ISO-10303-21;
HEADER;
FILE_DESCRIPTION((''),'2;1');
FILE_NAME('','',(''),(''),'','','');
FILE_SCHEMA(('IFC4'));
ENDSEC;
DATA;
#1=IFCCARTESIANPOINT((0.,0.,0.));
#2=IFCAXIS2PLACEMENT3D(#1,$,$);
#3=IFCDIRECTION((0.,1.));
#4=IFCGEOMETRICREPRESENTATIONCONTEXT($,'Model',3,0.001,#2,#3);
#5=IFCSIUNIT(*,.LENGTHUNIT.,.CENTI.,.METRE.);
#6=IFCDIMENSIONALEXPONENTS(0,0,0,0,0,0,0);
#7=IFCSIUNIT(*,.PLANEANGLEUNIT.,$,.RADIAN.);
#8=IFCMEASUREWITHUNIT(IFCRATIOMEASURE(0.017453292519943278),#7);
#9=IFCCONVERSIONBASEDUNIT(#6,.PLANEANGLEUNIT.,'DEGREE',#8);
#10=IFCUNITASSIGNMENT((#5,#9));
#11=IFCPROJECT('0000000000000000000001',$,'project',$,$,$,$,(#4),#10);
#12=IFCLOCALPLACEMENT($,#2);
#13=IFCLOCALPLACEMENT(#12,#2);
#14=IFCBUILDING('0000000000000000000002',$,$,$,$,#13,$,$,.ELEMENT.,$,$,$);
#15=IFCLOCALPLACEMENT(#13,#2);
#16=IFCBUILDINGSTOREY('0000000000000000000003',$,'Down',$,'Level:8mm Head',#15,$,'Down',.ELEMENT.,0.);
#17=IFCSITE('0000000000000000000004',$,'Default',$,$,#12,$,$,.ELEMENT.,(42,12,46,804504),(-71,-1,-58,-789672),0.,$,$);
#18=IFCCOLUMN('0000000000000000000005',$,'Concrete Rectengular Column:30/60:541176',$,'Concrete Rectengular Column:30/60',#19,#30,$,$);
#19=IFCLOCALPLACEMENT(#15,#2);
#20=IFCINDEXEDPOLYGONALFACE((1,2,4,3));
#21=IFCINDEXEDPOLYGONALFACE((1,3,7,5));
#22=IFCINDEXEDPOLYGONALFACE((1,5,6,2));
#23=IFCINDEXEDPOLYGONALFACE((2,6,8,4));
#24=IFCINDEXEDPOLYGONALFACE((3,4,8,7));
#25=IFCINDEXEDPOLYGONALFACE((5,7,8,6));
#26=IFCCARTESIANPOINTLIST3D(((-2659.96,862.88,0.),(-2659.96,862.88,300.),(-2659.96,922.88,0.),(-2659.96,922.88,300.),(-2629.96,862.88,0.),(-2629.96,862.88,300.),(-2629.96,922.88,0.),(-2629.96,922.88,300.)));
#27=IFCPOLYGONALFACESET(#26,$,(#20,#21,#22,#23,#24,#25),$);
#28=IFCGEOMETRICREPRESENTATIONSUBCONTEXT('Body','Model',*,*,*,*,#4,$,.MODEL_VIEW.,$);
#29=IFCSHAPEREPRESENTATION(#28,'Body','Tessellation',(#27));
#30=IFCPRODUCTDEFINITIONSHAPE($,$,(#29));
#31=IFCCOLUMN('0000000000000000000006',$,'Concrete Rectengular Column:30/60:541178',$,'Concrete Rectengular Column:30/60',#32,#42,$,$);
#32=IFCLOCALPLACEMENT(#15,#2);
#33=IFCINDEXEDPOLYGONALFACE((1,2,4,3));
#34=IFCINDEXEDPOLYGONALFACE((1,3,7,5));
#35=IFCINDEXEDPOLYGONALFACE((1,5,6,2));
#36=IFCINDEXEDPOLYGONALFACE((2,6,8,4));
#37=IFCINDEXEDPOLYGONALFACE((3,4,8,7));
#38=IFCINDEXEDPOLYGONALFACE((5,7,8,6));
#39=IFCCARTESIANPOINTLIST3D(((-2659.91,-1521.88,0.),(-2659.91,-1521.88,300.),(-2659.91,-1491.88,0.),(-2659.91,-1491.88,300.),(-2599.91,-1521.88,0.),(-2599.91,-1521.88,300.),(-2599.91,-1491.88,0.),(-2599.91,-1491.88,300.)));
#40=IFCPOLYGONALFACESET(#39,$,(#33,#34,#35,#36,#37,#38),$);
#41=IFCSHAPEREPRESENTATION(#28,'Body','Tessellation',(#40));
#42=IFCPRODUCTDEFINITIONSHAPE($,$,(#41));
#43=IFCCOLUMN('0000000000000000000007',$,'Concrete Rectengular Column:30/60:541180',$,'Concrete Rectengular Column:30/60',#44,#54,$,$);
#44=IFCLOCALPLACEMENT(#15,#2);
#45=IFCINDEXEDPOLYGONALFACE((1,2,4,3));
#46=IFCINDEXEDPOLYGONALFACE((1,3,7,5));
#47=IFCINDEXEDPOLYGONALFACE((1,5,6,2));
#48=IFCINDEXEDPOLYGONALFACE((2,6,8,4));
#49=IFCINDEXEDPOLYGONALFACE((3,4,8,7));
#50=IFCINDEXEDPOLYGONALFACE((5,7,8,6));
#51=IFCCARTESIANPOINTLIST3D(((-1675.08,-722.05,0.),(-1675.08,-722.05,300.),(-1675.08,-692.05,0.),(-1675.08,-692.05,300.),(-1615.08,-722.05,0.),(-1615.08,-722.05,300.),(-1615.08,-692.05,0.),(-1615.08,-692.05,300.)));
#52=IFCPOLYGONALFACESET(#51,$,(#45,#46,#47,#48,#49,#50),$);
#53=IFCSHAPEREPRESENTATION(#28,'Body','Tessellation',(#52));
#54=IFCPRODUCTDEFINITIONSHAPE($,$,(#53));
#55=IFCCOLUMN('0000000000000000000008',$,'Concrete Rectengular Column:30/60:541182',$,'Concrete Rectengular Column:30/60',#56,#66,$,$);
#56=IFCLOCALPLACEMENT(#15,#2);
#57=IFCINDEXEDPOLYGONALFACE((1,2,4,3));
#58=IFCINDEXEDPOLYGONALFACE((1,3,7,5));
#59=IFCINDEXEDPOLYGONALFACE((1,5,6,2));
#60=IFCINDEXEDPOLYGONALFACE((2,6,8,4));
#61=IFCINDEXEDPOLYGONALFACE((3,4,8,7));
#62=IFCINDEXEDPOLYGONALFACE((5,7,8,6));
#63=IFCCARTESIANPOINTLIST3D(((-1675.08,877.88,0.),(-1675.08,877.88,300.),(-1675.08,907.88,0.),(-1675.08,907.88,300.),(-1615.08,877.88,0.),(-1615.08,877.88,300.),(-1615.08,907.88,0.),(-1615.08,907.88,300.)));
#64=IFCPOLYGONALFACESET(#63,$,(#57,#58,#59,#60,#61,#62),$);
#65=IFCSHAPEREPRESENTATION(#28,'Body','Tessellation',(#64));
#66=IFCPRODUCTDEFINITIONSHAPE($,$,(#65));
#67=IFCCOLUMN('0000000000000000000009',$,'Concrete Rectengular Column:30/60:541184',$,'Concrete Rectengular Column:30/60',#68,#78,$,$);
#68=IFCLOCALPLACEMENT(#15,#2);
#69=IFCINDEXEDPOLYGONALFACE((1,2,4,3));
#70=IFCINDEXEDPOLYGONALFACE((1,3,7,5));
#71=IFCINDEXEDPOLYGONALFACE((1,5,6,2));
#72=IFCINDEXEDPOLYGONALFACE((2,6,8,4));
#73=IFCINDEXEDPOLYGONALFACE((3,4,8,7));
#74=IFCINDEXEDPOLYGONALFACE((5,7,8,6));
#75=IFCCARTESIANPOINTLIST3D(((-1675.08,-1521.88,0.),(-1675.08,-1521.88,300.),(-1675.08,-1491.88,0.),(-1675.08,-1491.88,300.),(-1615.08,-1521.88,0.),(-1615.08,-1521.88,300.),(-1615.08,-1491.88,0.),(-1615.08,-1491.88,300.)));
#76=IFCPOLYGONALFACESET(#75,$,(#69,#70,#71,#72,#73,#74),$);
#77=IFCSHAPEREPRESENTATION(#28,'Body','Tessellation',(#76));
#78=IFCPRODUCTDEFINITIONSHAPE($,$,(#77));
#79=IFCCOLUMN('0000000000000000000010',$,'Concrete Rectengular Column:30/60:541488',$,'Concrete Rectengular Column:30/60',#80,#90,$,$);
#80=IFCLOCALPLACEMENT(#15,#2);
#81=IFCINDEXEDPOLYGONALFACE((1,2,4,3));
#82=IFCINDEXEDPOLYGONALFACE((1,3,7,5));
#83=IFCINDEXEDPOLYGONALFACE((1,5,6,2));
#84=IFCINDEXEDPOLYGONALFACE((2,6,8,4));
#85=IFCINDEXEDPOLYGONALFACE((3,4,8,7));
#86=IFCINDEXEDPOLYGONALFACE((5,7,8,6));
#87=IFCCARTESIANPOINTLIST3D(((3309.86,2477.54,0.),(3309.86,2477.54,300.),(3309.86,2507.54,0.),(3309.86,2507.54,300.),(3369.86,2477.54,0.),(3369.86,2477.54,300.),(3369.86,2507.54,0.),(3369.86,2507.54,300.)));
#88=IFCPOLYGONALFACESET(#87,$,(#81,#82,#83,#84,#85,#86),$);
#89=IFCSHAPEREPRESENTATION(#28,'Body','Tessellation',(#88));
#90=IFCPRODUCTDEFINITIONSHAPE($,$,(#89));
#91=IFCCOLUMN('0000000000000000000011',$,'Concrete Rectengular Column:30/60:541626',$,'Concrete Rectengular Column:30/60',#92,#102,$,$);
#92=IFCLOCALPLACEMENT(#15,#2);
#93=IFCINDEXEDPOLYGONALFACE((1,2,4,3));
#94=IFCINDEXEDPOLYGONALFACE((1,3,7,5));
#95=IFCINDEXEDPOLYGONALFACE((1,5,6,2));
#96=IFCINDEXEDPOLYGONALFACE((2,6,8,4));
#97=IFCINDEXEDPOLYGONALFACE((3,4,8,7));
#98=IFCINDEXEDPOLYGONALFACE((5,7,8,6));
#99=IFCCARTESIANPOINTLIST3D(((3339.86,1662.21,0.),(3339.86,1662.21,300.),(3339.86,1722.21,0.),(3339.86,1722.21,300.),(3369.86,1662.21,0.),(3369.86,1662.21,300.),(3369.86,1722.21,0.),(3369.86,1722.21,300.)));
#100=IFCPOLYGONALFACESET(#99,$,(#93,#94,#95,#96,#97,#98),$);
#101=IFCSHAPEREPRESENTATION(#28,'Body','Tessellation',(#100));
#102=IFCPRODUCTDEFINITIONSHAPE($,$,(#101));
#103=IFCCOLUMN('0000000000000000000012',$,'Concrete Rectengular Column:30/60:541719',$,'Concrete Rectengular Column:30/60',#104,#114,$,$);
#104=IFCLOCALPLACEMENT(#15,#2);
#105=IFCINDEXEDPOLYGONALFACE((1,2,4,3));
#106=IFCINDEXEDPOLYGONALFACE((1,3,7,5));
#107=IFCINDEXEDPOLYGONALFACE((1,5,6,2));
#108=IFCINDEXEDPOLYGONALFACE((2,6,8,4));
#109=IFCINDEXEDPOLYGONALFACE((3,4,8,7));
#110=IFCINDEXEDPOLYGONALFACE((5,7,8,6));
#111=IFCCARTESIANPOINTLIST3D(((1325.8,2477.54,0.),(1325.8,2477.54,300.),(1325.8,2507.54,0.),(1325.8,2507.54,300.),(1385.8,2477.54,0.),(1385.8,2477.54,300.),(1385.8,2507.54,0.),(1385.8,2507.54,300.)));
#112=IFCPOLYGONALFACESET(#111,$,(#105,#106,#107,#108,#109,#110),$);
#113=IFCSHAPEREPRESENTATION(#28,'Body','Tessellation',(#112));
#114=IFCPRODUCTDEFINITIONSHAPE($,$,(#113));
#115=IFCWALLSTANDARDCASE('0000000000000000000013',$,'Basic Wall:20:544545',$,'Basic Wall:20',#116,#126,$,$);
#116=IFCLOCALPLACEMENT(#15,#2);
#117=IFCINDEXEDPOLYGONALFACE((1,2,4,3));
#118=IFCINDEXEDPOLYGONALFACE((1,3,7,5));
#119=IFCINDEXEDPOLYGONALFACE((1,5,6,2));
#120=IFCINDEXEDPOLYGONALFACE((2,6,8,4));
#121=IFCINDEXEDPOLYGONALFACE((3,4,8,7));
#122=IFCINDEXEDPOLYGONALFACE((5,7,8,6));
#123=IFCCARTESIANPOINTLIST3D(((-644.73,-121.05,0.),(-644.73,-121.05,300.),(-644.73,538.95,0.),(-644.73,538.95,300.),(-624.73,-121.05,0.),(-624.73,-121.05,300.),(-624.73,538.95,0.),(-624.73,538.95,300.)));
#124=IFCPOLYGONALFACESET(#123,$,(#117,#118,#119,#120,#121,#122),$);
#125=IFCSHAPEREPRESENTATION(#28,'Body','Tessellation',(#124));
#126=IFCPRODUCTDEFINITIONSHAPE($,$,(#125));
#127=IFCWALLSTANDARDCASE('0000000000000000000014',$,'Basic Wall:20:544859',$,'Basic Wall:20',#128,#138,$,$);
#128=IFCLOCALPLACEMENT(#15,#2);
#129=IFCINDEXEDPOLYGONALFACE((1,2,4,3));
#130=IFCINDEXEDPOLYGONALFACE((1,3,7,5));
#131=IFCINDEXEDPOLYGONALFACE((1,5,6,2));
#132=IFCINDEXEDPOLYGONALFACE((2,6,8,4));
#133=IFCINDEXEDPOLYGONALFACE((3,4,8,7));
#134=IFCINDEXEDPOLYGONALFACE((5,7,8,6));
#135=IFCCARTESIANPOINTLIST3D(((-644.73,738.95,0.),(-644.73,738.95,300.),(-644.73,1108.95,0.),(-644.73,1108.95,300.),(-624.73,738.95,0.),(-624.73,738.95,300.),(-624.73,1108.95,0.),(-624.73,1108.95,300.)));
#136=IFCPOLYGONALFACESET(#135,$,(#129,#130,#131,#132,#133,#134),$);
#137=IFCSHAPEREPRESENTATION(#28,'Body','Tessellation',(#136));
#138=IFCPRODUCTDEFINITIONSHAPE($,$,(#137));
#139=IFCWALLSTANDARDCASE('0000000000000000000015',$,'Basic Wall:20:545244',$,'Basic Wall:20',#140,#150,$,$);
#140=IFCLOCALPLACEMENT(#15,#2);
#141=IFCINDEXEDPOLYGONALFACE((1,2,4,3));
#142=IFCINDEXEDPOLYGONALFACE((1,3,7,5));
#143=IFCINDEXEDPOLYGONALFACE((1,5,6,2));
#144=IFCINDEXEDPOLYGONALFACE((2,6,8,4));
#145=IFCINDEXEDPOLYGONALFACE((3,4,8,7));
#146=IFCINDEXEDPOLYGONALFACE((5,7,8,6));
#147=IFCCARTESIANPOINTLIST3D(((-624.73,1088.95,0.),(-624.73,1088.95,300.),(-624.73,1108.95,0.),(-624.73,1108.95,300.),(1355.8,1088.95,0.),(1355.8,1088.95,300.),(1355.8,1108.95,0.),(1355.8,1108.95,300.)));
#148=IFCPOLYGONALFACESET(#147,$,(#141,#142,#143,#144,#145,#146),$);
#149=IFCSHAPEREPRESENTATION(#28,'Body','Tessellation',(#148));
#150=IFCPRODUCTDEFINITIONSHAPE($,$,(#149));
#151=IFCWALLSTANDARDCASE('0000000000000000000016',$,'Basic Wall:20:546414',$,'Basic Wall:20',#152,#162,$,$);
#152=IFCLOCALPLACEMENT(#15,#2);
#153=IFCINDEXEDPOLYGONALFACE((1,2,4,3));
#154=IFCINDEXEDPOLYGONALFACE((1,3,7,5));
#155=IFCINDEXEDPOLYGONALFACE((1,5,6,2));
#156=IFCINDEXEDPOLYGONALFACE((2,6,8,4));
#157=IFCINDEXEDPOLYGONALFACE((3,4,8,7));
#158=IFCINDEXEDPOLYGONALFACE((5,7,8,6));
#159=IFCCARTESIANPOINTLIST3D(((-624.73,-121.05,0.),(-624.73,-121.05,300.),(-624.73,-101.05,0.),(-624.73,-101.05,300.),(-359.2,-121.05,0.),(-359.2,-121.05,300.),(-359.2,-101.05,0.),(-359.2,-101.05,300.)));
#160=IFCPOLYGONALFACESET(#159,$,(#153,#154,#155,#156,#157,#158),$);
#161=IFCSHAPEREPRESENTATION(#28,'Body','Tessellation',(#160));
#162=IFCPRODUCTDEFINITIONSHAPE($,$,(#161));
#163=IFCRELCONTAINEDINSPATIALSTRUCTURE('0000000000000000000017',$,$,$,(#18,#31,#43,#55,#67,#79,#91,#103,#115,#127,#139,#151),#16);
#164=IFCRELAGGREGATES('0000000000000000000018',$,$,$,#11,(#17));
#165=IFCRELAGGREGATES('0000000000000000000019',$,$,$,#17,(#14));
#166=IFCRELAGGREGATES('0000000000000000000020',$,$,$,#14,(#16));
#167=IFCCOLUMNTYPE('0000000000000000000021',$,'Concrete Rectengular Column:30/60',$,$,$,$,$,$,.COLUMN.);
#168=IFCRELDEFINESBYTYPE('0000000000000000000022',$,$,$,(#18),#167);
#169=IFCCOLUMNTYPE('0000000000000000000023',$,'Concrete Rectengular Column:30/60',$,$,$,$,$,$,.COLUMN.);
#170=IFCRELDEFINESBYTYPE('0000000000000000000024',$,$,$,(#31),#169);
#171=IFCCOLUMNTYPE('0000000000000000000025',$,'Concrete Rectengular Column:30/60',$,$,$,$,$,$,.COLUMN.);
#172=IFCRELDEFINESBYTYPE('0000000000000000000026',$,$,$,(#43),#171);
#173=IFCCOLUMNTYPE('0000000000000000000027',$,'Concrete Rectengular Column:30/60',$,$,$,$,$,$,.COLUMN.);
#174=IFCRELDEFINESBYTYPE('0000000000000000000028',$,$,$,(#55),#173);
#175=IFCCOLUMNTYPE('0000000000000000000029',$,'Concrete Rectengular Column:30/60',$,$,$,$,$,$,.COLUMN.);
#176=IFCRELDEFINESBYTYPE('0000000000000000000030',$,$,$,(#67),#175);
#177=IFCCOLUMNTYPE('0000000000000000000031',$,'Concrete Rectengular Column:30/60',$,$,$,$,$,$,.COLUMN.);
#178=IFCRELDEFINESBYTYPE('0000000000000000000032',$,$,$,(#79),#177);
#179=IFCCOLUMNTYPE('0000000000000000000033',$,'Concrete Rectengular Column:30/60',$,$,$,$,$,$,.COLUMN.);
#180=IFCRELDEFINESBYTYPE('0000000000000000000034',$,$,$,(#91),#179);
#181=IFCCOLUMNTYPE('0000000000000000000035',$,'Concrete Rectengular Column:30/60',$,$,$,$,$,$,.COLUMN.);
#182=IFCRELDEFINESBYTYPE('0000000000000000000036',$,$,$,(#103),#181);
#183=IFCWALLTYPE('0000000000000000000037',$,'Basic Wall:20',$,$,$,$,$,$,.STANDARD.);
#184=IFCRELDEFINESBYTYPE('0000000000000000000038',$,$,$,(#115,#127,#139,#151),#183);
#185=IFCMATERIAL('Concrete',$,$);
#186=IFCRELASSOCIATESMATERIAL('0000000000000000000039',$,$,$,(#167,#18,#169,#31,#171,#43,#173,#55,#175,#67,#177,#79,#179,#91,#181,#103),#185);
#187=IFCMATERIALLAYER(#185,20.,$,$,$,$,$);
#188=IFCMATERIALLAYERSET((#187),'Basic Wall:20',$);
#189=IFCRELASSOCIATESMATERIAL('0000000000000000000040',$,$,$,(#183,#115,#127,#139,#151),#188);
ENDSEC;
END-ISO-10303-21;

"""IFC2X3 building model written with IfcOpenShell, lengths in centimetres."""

from ifc_helpers import new_model, entity, si_unit, converted_unit, direction, frame, frame_2d, origin, origin_2d_with_axis, place, context, subcontext, project, spatial, rectangle, extrude, source, transform, mapped, material, layer, layer_set, layer_usage, type_object, type_shapes, element, save


model = new_model("IFC2X3")

# Units and contexts
model_context = context("Model", 3, precision=0.001, world=origin(), true_north=direction((0.0, 1.0)))
body_context = subcontext(model_context, "Body", "Model", "MODEL_VIEW")
ifc_project = project(units=[si_unit("LENGTHUNIT", "METRE", prefix="CENTI"), converted_unit("PLANEANGLEUNIT", "DEGREE", entity("IfcRatioMeasure", 0.017453292519943278), si_unit("PLANEANGLEUNIT", "RADIAN"), dimensions=[0, 0, 0, 0, 0, 0, 0])], contexts=[model_context])

# Site, building, storey
site_placement = place(None, origin())
site = spatial("IfcSite", under=ifc_project, at=site_placement, Name="Default", CompositionType="ELEMENT", RefLatitude=(42, 12, 46, 804504), RefLongitude=(-71, -1, -58, -789672), RefElevation=0.0)
building_placement = place(site_placement, origin())
building = spatial("IfcBuilding", under=site, at=building_placement, CompositionType="ELEMENT")
storey_placement = place(building_placement, origin())
storey = spatial("IfcBuildingStorey", under=building, at=storey_placement, Name="Down", ObjectType="Level:8mm Head", LongName="Down", CompositionType="ELEMENT", Elevation=0.0)

# Columns
ifc_material = material(Name="Concrete")
column_type_1 = type_object("IfcColumnType", Name="Concrete Rectengular Column:30/60", PredefinedType="COLUMN", material=ifc_material)
shared_shape_1 = source(origin(), body_context, "Body", "SweptSolid", [
    extrude(rectangle(XDim=60.0, YDim=30.0, at=origin_2d_with_axis()), frame((-2644.96, 892.88, 0.0), z_axis=(0.0, 0.0, 1.0), x_axis=(0.0, -1.0, 0.0)), (0.0, 0.0, 1.0), 300.0),
])
type_shapes(column_type_1, [shared_shape_1])
column_1_placement = place(storey_placement, origin())
element("IfcColumn", 1, at=column_1_placement, inside=storey, type_object=column_type_1, material=ifc_material, Name="Concrete Rectengular Column:30/60:541176", ObjectType="Concrete Rectengular Column:30/60", context=body_context, shape_type="MappedRepresentation", body=[
    mapped(shared_shape_1, transform((0.0, 0.0, 0.0), scale=1.0)),
])
column_type_2 = type_object("IfcColumnType", Name="Concrete Rectengular Column:30/60", PredefinedType="COLUMN", material=ifc_material)
shared_shape_2 = source(origin(), body_context, "Body", "SweptSolid", [
    extrude(rectangle(XDim=30.0, YDim=60.0, at=origin_2d_with_axis()), frame((-2629.91, -1506.88, 0.0), z_axis=(0.0, 0.0, 1.0), x_axis=(0.0, -1.0, 0.0)), (0.0, 0.0, 1.0), 300.0),
])
type_shapes(column_type_2, [shared_shape_2])
column_2_placement = place(storey_placement, origin())
element("IfcColumn", 2, at=column_2_placement, inside=storey, type_object=column_type_2, material=ifc_material, Name="Concrete Rectengular Column:30/60:541178", ObjectType="Concrete Rectengular Column:30/60", context=body_context, shape_type="MappedRepresentation", body=[
    mapped(shared_shape_2, transform((0.0, 0.0, 0.0), scale=1.0)),
])
column_type_3 = type_object("IfcColumnType", Name="Concrete Rectengular Column:30/60", PredefinedType="COLUMN", material=ifc_material)
shared_shape_3 = source(origin(), body_context, "Body", "SweptSolid", [
    extrude(rectangle(XDim=30.0, YDim=60.0, at=frame_2d((0.0, 0.0), x_axis=(1.0, 0.0))), frame((-1645.08, -707.05, 0.0), z_axis=(0.0, 0.0, 1.0), x_axis=(0.0, -1.0, 0.0)), (0.0, 0.0, 1.0), 300.0),
])
type_shapes(column_type_3, [shared_shape_3])
column_3_placement = place(storey_placement, origin())
element("IfcColumn", 3, at=column_3_placement, inside=storey, type_object=column_type_3, material=ifc_material, Name="Concrete Rectengular Column:30/60:541180", ObjectType="Concrete Rectengular Column:30/60", context=body_context, shape_type="MappedRepresentation", body=[
    mapped(shared_shape_3, transform((0.0, 0.0, 0.0), scale=1.0)),
])
column_type_4 = type_object("IfcColumnType", Name="Concrete Rectengular Column:30/60", PredefinedType="COLUMN", material=ifc_material)
shared_shape_4 = source(origin(), body_context, "Body", "SweptSolid", [
    extrude(rectangle(XDim=30.0, YDim=60.0, at=frame_2d((0.0, 0.0), x_axis=(1.0, 0.0))), frame((-1645.08, 892.88, 0.0), z_axis=(0.0, 0.0, 1.0), x_axis=(0.0, -1.0, 0.0)), (0.0, 0.0, 1.0), 300.0),
])
type_shapes(column_type_4, [shared_shape_4])
column_4_placement = place(storey_placement, origin())
element("IfcColumn", 4, at=column_4_placement, inside=storey, type_object=column_type_4, material=ifc_material, Name="Concrete Rectengular Column:30/60:541182", ObjectType="Concrete Rectengular Column:30/60", context=body_context, shape_type="MappedRepresentation", body=[
    mapped(shared_shape_4, transform((0.0, 0.0, 0.0), scale=1.0)),
])
column_type_5 = type_object("IfcColumnType", Name="Concrete Rectengular Column:30/60", PredefinedType="COLUMN", material=ifc_material)
shared_shape_5 = source(origin(), body_context, "Body", "SweptSolid", [
    extrude(rectangle(XDim=30.0, YDim=60.0, at=frame_2d((0.0, 0.0), x_axis=(1.0, 0.0))), frame((-1645.08, -1506.88, 0.0), z_axis=(0.0, 0.0, 1.0), x_axis=(0.0, -1.0, 0.0)), (0.0, 0.0, 1.0), 300.0),
])
type_shapes(column_type_5, [shared_shape_5])
column_5_placement = place(storey_placement, origin())
element("IfcColumn", 5, at=column_5_placement, inside=storey, type_object=column_type_5, material=ifc_material, Name="Concrete Rectengular Column:30/60:541184", ObjectType="Concrete Rectengular Column:30/60", context=body_context, shape_type="MappedRepresentation", body=[
    mapped(shared_shape_5, transform((0.0, 0.0, 0.0), scale=1.0)),
])
column_type_6 = type_object("IfcColumnType", Name="Concrete Rectengular Column:30/60", PredefinedType="COLUMN", material=ifc_material)
shared_shape_6 = source(origin(), body_context, "Body", "SweptSolid", [
    extrude(rectangle(XDim=30.0, YDim=60.0, at=origin_2d_with_axis()), frame((3339.86, 2492.54, 0.0), z_axis=(0.0, 0.0, 1.0), x_axis=(0.0, -1.0, 0.0)), (0.0, 0.0, 1.0), 300.0),
])
type_shapes(column_type_6, [shared_shape_6])
column_6_placement = place(storey_placement, origin())
element("IfcColumn", 6, at=column_6_placement, inside=storey, type_object=column_type_6, material=ifc_material, Name="Concrete Rectengular Column:30/60:541488", ObjectType="Concrete Rectengular Column:30/60", context=body_context, shape_type="MappedRepresentation", body=[
    mapped(shared_shape_6, transform((0.0, 0.0, 0.0), scale=1.0)),
])
column_type_7 = type_object("IfcColumnType", Name="Concrete Rectengular Column:30/60", PredefinedType="COLUMN", material=ifc_material)
shared_shape_7 = source(origin(), body_context, "Body", "SweptSolid", [
    extrude(rectangle(XDim=60.0, YDim=30.0, at=frame_2d((0.0, 0.0), x_axis=(1.0, 0.0))), frame((3354.86, 1692.21, 0.0), z_axis=(0.0, 0.0, 1.0), x_axis=(0.0, -1.0, 0.0)), (0.0, 0.0, 1.0), 300.0),
])
type_shapes(column_type_7, [shared_shape_7])
column_7_placement = place(storey_placement, origin())
element("IfcColumn", 7, at=column_7_placement, inside=storey, type_object=column_type_7, material=ifc_material, Name="Concrete Rectengular Column:30/60:541626", ObjectType="Concrete Rectengular Column:30/60", context=body_context, shape_type="MappedRepresentation", body=[
    mapped(shared_shape_7, transform((0.0, 0.0, 0.0), scale=1.0)),
])
column_type_8 = type_object("IfcColumnType", Name="Concrete Rectengular Column:30/60", PredefinedType="COLUMN", material=ifc_material)
shared_shape_8 = source(origin(), body_context, "Body", "SweptSolid", [
    extrude(rectangle(XDim=30.0, YDim=60.0, at=frame_2d((0.0, 0.0), x_axis=(1.0, 0.0))), frame((1355.8, 2492.54, 0.0), z_axis=(0.0, 0.0, 1.0), x_axis=(0.0, -1.0, 0.0)), (0.0, 0.0, 1.0), 300.0),
])
type_shapes(column_type_8, [shared_shape_8])
column_8_placement = place(storey_placement, origin())
element("IfcColumn", 8, at=column_8_placement, inside=storey, type_object=column_type_8, material=ifc_material, Name="Concrete Rectengular Column:30/60:541719", ObjectType="Concrete Rectengular Column:30/60", context=body_context, shape_type="MappedRepresentation", body=[
    mapped(shared_shape_8, transform((0.0, 0.0, 0.0), scale=1.0)),
])

# Walls
ifc_layer_1 = layer(ifc_material, 20.0)
ifc_layer_set_1 = layer_set([ifc_layer_1], Name="Basic Wall:20")
ifc_layer_usage_1 = layer_usage(ifc_layer_set_1, "AXIS2", "NEGATIVE", 10.0)
wall_type_1 = type_object("IfcWallType", Name="Basic Wall:20", PredefinedType="STANDARD", material=ifc_layer_set_1)
wall_1_placement = place(storey_placement, frame((-634.73, -121.05, 0.0), z_axis=(0.0, 0.0, 1.0), x_axis=(0.0, 1.0, 0.0)))
element("IfcWallStandardCase", 9, at=wall_1_placement, inside=storey, type_object=wall_type_1, material=ifc_layer_usage_1, Name="Basic Wall:20:544545", ObjectType="Basic Wall:20", context=body_context, shape_type="SweptSolid", body=[
    extrude(rectangle(XDim=660.0, YDim=20.0, at=frame_2d((330.0, 0.0), x_axis=(-1.0, 0.0))), origin(), (0.0, 0.0, 1.0), 300.0),
])
ifc_layer_usage_2 = layer_usage(ifc_layer_set_1, "AXIS2", "NEGATIVE", 10.0)
wall_2_placement = place(storey_placement, frame((-634.73, 738.95, 0.0), z_axis=(0.0, 0.0, 1.0), x_axis=(0.0, 1.0, 0.0)))
element("IfcWallStandardCase", 10, at=wall_2_placement, inside=storey, type_object=wall_type_1, material=ifc_layer_usage_2, Name="Basic Wall:20:544859", ObjectType="Basic Wall:20", context=body_context, shape_type="SweptSolid", body=[
    extrude(rectangle(XDim=370.0, YDim=20.0, at=frame_2d((185.0, 0.0), x_axis=(-1.0, 0.0))), origin(), (0.0, 0.0, 1.0), 300.0),
])
ifc_layer_usage_3 = layer_usage(ifc_layer_set_1, "AXIS2", "NEGATIVE", 10.0)
wall_3_placement = place(storey_placement, frame((-624.73, 1098.95, 0.0)))
element("IfcWallStandardCase", 11, at=wall_3_placement, inside=storey, type_object=wall_type_1, material=ifc_layer_usage_3, Name="Basic Wall:20:545244", ObjectType="Basic Wall:20", context=body_context, shape_type="SweptSolid", body=[
    extrude(rectangle(XDim=1980.53, YDim=20.0, at=frame_2d((990.27, 0.0), x_axis=(-1.0, 0.0))), origin(), (0.0, 0.0, 1.0), 300.0),
])
ifc_layer_usage_4 = layer_usage(ifc_layer_set_1, "AXIS2", "NEGATIVE", 10.0)
wall_4_placement = place(storey_placement, frame((-359.2, -111.05, 0.0), z_axis=(0.0, 0.0, 1.0), x_axis=(-1.0, 0.0, 0.0)))
element("IfcWallStandardCase", 12, at=wall_4_placement, inside=storey, type_object=wall_type_1, material=ifc_layer_usage_4, Name="Basic Wall:20:546414", ObjectType="Basic Wall:20", context=body_context, shape_type="SweptSolid", body=[
    extrude(rectangle(XDim=265.53, YDim=20.0, at=frame_2d((132.77, 0.0), x_axis=(-1.0, 0.0))), origin(), (0.0, 0.0, 1.0), 300.0),
])

save(model, "model.ifc")
